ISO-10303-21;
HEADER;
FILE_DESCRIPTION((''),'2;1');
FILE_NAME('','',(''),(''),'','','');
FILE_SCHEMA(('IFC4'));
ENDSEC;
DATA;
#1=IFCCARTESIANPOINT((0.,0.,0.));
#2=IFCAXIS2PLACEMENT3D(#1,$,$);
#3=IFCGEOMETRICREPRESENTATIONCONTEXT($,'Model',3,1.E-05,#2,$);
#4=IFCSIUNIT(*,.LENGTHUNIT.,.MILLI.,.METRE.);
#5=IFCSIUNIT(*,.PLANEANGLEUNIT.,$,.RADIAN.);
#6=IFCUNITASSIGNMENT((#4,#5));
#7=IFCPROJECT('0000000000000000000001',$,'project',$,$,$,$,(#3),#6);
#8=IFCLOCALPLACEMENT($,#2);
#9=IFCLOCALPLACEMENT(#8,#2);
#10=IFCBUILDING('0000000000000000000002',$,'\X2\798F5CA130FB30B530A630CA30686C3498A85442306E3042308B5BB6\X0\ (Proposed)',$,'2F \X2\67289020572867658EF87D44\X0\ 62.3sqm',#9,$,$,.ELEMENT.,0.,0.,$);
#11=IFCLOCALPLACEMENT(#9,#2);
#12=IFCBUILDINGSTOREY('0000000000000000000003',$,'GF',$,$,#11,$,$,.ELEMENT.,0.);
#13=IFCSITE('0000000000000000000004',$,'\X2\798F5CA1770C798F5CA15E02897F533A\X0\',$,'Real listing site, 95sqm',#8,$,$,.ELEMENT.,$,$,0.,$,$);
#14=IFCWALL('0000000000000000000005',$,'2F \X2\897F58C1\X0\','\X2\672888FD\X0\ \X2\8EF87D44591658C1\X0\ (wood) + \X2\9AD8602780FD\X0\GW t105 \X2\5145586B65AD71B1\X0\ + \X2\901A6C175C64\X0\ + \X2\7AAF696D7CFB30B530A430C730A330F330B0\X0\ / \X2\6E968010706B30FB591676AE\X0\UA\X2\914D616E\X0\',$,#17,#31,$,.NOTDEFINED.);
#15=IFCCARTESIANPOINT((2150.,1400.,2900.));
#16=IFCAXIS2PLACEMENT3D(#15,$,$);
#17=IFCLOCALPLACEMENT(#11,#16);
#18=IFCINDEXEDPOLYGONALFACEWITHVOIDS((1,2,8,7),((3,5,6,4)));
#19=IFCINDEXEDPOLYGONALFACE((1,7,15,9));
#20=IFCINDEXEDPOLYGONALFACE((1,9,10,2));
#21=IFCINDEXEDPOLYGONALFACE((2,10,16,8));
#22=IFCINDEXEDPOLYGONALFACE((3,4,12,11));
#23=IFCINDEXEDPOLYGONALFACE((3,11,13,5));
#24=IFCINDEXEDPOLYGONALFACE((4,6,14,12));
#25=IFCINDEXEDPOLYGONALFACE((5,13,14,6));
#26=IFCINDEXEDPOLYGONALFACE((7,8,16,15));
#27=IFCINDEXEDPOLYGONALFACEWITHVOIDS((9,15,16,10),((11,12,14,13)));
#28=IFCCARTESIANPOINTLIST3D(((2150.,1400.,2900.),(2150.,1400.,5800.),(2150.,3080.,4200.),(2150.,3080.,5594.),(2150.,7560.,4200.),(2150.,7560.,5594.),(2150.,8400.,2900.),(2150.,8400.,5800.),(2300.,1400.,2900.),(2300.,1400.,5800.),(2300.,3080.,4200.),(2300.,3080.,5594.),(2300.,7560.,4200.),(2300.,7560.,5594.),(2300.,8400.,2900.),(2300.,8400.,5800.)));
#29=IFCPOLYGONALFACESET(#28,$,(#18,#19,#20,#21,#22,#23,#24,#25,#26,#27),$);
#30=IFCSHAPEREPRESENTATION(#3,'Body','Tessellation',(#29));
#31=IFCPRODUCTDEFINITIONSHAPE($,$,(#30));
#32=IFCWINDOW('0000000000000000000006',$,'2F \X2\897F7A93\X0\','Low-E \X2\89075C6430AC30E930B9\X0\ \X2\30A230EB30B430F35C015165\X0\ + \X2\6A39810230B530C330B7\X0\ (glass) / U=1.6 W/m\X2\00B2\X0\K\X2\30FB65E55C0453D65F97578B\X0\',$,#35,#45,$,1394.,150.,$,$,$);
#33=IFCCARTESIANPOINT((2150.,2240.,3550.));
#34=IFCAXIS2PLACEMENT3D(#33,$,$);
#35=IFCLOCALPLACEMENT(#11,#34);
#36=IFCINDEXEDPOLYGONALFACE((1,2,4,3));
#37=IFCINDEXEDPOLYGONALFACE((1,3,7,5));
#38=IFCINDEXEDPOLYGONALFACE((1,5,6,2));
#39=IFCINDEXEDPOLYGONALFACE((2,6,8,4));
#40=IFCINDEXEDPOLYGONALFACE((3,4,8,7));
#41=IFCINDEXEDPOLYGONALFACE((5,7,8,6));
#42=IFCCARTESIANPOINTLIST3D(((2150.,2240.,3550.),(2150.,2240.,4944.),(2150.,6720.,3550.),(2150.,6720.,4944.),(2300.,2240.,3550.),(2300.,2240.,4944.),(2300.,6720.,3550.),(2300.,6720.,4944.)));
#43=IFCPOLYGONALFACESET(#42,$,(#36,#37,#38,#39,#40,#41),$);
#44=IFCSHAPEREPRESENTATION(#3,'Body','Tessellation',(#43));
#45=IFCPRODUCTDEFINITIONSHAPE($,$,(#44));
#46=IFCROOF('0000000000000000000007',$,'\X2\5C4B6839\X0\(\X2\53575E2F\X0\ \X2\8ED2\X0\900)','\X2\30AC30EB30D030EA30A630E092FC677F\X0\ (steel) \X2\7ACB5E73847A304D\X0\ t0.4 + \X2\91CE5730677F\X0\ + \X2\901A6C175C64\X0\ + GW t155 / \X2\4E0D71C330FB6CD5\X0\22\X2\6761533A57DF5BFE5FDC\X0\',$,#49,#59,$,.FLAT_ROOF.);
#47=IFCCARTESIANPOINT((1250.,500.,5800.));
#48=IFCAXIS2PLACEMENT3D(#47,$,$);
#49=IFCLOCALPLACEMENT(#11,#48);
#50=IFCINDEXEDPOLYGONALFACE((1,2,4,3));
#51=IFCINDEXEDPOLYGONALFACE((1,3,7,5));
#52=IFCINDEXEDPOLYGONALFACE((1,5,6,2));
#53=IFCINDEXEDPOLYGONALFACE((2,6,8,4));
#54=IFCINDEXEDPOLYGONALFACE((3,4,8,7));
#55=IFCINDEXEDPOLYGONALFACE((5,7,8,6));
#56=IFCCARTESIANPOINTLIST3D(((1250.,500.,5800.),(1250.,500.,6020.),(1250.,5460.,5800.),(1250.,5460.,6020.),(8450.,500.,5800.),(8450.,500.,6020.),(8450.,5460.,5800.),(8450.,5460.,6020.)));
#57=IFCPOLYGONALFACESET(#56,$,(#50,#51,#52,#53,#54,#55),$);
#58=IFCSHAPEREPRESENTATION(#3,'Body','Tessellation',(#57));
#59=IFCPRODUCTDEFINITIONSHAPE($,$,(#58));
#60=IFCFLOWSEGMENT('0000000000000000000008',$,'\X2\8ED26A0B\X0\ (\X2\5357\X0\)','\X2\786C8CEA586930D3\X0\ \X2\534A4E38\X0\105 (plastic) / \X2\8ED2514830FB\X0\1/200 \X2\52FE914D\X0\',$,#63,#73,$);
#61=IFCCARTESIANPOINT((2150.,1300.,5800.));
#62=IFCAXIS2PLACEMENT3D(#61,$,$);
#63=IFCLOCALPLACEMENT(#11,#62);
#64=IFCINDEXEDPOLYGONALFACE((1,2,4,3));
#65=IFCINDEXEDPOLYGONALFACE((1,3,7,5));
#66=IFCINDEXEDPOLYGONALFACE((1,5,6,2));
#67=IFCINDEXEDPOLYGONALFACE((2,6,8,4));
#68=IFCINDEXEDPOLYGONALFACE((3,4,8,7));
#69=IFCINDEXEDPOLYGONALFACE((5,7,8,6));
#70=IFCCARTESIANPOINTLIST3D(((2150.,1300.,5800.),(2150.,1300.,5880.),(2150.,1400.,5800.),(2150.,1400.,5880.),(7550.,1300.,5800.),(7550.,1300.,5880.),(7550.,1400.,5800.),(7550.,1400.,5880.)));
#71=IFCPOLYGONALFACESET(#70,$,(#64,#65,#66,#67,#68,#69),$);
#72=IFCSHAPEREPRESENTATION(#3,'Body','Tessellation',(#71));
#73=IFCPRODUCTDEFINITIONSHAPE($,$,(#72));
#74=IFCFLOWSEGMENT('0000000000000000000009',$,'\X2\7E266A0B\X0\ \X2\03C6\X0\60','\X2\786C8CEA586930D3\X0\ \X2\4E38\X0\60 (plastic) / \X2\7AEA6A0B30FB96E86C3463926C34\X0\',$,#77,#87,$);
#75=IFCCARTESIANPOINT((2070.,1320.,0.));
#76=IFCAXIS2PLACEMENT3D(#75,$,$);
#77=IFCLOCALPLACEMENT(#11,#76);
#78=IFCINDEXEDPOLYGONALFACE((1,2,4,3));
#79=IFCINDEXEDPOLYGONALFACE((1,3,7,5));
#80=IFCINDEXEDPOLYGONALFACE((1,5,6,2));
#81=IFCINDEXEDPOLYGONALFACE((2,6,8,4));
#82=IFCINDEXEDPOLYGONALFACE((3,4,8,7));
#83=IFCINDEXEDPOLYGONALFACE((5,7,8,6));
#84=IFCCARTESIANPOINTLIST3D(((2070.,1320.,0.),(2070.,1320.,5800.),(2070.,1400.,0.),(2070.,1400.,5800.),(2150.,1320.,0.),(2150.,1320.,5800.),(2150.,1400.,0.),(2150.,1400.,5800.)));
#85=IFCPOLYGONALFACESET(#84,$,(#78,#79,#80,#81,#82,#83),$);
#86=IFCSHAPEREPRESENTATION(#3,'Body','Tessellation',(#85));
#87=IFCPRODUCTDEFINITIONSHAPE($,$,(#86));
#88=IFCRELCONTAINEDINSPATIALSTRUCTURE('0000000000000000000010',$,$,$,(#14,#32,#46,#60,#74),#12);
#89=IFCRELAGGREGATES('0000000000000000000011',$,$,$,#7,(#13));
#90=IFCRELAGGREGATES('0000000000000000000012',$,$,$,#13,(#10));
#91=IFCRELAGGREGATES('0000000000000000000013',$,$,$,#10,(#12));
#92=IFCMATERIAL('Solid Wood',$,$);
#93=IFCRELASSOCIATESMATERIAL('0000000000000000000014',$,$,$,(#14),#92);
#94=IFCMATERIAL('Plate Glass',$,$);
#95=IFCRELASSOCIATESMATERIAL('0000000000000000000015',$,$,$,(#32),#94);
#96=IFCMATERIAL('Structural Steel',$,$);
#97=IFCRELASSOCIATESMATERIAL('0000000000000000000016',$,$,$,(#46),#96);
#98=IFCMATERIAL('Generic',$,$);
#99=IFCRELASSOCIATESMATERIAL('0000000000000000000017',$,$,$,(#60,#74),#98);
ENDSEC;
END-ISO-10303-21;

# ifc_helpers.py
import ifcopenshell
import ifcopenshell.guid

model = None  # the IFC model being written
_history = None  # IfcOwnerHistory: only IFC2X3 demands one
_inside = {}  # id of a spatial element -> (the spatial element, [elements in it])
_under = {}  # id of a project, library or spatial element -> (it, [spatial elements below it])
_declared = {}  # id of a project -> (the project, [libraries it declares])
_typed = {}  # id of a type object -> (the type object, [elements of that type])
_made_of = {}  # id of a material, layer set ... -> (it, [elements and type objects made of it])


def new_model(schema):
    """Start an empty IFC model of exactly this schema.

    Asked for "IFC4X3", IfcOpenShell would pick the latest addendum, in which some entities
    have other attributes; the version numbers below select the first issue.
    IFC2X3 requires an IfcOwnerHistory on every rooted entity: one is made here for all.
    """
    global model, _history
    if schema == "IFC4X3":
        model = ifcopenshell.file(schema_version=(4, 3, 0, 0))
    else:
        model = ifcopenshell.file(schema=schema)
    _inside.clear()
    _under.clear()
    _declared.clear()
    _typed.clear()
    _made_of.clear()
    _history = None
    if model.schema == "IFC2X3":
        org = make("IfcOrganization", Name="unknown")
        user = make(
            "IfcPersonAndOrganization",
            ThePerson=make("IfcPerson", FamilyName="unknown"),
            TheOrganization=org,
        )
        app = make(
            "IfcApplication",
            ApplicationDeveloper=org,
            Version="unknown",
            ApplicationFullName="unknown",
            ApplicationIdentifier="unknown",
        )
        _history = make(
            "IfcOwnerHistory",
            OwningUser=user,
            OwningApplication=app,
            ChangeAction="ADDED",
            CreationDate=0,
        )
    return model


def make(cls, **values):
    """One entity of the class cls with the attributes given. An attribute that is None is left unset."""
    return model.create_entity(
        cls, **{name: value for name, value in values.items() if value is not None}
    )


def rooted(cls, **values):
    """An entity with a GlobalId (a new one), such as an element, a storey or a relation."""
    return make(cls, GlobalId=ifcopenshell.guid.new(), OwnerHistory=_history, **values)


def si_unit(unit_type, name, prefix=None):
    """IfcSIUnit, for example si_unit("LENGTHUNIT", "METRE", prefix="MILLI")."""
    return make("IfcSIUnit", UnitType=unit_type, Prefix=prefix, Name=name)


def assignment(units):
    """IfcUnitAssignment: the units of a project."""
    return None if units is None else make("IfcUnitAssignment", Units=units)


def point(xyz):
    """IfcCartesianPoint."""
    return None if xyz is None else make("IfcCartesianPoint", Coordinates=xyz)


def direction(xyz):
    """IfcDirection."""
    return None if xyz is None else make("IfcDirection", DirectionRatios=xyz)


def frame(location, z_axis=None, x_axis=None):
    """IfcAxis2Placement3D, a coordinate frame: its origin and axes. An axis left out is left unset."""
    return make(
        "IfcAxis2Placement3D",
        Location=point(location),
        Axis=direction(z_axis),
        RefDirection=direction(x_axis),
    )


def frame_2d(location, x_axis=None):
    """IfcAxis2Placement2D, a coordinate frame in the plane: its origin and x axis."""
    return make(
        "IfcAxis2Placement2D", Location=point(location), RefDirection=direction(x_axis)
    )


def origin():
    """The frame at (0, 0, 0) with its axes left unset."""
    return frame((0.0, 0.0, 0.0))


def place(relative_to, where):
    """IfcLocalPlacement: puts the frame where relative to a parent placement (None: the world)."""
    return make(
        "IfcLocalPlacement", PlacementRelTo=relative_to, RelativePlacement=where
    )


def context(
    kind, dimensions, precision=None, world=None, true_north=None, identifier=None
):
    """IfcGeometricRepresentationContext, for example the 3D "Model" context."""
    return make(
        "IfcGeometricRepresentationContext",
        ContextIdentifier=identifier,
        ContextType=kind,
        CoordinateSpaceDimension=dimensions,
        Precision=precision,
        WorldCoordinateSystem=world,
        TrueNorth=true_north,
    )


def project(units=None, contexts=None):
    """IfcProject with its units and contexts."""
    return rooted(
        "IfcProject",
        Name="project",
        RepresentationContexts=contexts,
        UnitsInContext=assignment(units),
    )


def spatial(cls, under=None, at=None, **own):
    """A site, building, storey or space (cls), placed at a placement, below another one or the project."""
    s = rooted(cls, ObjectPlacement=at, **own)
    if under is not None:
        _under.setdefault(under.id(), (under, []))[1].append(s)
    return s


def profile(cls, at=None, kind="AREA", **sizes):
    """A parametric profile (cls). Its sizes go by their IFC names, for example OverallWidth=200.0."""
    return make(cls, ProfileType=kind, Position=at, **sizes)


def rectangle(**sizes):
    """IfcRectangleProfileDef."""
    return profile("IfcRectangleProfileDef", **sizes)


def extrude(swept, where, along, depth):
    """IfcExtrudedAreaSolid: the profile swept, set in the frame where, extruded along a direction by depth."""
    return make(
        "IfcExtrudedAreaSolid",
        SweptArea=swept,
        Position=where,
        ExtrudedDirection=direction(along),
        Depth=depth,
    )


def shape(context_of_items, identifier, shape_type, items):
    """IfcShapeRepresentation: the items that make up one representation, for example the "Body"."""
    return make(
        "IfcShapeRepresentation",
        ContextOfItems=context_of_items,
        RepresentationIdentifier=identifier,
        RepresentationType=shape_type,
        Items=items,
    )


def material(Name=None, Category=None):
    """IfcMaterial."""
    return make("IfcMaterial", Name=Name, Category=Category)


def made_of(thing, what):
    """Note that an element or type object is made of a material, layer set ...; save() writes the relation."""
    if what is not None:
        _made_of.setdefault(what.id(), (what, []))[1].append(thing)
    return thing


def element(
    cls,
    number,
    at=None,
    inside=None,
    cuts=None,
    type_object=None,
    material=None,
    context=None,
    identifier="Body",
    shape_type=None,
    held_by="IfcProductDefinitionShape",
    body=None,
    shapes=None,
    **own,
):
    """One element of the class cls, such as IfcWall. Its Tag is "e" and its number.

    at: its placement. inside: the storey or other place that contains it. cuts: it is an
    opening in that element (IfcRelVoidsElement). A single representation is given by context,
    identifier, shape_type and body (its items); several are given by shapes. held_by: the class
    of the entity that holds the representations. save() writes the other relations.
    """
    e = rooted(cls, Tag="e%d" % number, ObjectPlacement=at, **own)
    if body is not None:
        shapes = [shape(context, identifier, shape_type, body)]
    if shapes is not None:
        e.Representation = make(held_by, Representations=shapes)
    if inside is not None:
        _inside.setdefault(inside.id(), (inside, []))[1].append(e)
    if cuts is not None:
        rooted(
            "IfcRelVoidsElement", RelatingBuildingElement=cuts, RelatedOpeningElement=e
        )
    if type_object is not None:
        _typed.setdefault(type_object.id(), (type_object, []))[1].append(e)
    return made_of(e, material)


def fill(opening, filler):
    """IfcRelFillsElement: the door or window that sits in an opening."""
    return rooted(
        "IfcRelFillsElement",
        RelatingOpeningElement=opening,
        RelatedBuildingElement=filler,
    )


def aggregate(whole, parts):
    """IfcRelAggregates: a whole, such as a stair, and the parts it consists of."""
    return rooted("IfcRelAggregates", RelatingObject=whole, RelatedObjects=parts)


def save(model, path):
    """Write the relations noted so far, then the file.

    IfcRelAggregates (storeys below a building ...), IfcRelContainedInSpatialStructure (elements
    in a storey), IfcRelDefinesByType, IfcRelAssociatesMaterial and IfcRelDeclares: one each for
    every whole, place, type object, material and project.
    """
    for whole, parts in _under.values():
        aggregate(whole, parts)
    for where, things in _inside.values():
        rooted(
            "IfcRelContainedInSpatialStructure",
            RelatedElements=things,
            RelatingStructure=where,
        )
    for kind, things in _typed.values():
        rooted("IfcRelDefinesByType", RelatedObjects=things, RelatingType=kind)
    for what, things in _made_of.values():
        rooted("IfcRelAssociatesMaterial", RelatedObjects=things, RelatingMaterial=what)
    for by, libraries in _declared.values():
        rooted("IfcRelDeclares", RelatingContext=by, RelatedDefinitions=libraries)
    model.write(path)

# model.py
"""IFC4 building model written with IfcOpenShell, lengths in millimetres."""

from ifc_helpers import new_model, si_unit, frame, frame_2d, origin, place, context, project, spatial, rectangle, extrude, material, element, fill, save


model = new_model("IFC4")

# Units and contexts
model_context = context("Model", 3, precision=1e-05, world=origin())
ifc_project = project(units=[si_unit("LENGTHUNIT", "METRE", prefix="MILLI"), si_unit("PLANEANGLEUNIT", "RADIAN")], contexts=[model_context])

# Site, building, storey
site_placement = place(None, origin())
site = spatial("IfcSite", under=ifc_project, at=site_placement, Name="福岡県福岡市西区", ObjectType="Real listing site, 95sqm", CompositionType="ELEMENT", RefElevation=0.0)
building_placement = place(site_placement, origin())
building = spatial("IfcBuilding", under=site, at=building_placement, Name="福岡・サウナと水風呂のある家 (Proposed)", ObjectType="2F 木造在来軸組 62.3sqm", CompositionType="ELEMENT", ElevationOfRefHeight=0.0, ElevationOfTerrain=0.0)
storey_placement = place(building_placement, origin())
storey = spatial("IfcBuildingStorey", under=building, at=storey_placement, Name="GF", CompositionType="ELEMENT", Elevation=0.0)

# Shared definitions
ifc_material_1 = material(Name="Solid Wood")

# Shared definitions
ifc_material_2 = material(Name="Plate Glass")

# Wall, opening, window
wall_1_placement = place(storey_placement, frame((2150.0, 1400.0, 2900.0)))
wall_1 = element("IfcWall", 1, at=wall_1_placement, inside=storey, material=ifc_material_1, Name="2F 西壁", Description="木製 軸組外壁 (wood) + 高性能GW t105 充填断熱 + 通気層 + 窯業系サイディング / 準耐火・外皮UA配慮", PredefinedType="NOTDEFINED", context=model_context, shape_type="SweptSolid", body=[
    extrude(rectangle(XDim=150.0, YDim=7000.0, at=frame_2d((75.0, 3500.0))), frame((2150.0, 1400.0, 2900.0)), (0.0, 0.0, 1.0), 2900.0),
])
opening_1_placement = place(storey_placement, frame((2150.0, 2240.0, 3550.0)))
opening_1 = element("IfcOpeningElement", 2, at=opening_1_placement, cuts=wall_1, PredefinedType="NOTDEFINED", context=model_context, shape_type="SweptSolid", body=[
    extrude(rectangle(XDim=150.0, YDim=4480.0, at=frame_2d((75.0, 2240.0))), frame((2150.0, 2240.0, 3550.0)), (0.0, 0.0, 1.0), 1394.0),
])
window_1_placement = place(storey_placement, frame((2150.0, 2240.0, 3550.0)))
window_1 = element("IfcWindow", 3, at=window_1_placement, inside=storey, material=ifc_material_2, Name="2F 西窓", Description="Low-E 複層ガラス アルゴン封入 + 樹脂サッシ (glass) / U=1.6 W/m²K・日射取得型", OverallHeight=1394.0, OverallWidth=150.0, context=model_context, shape_type="SweptSolid", body=[
    extrude(rectangle(XDim=150.0, YDim=4480.0, at=frame_2d((75.0, 2240.0))), frame((2150.0, 2240.0, 3550.0)), (0.0, 0.0, 1.0), 1394.0),
])
fill(opening_1, window_1)

# Roof
ifc_material_3 = material(Name="Structural Steel")
for number, where, name in (
    (4, (1250.0, 500.0, 5800.0), "屋根(南帯 軒900)"),
):
    element("IfcRoof", number, at=place(storey_placement, frame(where)), inside=storey, material=ifc_material_3, Name=name, Description="ガルバリウム鋼板 (steel) 立平葺き t0.4 + 野地板 + 通気層 + GW t155 / 不燃・法22条区域対応", PredefinedType="FLAT_ROOF", context=model_context, shape_type="SweptSolid", body=[
        extrude(rectangle(XDim=7200.0, YDim=4960.0, at=frame_2d((3600.0, 2480.0))), frame((1250.0, 500.0, 5800.0)), (0.0, 0.0, 1.0), 220.0),
    ])

# Flow segments
ifc_material_4 = material(Name="Generic")
flow_segment_1_placement = place(storey_placement, frame((2150.0, 1300.0, 5800.0)))
element("IfcFlowSegment", 5, at=flow_segment_1_placement, inside=storey, material=ifc_material_4, Name="軒樋 (南)", Description="硬質塩ビ 半丸105 (plastic) / 軒先・1/200 勾配", context=model_context, shape_type="SweptSolid", body=[
    extrude(rectangle(XDim=5400.0, YDim=100.0, at=frame_2d((2700.0, 50.0))), frame((2150.0, 1300.0, 5800.0)), (0.0, 0.0, 1.0), 80.0),
])
flow_segment_2_placement = place(storey_placement, frame((2070.0, 1320.0, 0.0)))
element("IfcFlowSegment", 6, at=flow_segment_2_placement, inside=storey, material=ifc_material_4, Name="縦樋 φ60", Description="硬質塩ビ 丸60 (plastic) / 竪樋・雨水排水", context=model_context, shape_type="SweptSolid", body=[
    extrude(rectangle(XDim=80.0, YDim=80.0, at=frame_2d((40.0, 40.0))), frame((2070.0, 1320.0, 0.0)), (0.0, 0.0, 1.0), 5800.0),
])

save(model, "model.ifc")
